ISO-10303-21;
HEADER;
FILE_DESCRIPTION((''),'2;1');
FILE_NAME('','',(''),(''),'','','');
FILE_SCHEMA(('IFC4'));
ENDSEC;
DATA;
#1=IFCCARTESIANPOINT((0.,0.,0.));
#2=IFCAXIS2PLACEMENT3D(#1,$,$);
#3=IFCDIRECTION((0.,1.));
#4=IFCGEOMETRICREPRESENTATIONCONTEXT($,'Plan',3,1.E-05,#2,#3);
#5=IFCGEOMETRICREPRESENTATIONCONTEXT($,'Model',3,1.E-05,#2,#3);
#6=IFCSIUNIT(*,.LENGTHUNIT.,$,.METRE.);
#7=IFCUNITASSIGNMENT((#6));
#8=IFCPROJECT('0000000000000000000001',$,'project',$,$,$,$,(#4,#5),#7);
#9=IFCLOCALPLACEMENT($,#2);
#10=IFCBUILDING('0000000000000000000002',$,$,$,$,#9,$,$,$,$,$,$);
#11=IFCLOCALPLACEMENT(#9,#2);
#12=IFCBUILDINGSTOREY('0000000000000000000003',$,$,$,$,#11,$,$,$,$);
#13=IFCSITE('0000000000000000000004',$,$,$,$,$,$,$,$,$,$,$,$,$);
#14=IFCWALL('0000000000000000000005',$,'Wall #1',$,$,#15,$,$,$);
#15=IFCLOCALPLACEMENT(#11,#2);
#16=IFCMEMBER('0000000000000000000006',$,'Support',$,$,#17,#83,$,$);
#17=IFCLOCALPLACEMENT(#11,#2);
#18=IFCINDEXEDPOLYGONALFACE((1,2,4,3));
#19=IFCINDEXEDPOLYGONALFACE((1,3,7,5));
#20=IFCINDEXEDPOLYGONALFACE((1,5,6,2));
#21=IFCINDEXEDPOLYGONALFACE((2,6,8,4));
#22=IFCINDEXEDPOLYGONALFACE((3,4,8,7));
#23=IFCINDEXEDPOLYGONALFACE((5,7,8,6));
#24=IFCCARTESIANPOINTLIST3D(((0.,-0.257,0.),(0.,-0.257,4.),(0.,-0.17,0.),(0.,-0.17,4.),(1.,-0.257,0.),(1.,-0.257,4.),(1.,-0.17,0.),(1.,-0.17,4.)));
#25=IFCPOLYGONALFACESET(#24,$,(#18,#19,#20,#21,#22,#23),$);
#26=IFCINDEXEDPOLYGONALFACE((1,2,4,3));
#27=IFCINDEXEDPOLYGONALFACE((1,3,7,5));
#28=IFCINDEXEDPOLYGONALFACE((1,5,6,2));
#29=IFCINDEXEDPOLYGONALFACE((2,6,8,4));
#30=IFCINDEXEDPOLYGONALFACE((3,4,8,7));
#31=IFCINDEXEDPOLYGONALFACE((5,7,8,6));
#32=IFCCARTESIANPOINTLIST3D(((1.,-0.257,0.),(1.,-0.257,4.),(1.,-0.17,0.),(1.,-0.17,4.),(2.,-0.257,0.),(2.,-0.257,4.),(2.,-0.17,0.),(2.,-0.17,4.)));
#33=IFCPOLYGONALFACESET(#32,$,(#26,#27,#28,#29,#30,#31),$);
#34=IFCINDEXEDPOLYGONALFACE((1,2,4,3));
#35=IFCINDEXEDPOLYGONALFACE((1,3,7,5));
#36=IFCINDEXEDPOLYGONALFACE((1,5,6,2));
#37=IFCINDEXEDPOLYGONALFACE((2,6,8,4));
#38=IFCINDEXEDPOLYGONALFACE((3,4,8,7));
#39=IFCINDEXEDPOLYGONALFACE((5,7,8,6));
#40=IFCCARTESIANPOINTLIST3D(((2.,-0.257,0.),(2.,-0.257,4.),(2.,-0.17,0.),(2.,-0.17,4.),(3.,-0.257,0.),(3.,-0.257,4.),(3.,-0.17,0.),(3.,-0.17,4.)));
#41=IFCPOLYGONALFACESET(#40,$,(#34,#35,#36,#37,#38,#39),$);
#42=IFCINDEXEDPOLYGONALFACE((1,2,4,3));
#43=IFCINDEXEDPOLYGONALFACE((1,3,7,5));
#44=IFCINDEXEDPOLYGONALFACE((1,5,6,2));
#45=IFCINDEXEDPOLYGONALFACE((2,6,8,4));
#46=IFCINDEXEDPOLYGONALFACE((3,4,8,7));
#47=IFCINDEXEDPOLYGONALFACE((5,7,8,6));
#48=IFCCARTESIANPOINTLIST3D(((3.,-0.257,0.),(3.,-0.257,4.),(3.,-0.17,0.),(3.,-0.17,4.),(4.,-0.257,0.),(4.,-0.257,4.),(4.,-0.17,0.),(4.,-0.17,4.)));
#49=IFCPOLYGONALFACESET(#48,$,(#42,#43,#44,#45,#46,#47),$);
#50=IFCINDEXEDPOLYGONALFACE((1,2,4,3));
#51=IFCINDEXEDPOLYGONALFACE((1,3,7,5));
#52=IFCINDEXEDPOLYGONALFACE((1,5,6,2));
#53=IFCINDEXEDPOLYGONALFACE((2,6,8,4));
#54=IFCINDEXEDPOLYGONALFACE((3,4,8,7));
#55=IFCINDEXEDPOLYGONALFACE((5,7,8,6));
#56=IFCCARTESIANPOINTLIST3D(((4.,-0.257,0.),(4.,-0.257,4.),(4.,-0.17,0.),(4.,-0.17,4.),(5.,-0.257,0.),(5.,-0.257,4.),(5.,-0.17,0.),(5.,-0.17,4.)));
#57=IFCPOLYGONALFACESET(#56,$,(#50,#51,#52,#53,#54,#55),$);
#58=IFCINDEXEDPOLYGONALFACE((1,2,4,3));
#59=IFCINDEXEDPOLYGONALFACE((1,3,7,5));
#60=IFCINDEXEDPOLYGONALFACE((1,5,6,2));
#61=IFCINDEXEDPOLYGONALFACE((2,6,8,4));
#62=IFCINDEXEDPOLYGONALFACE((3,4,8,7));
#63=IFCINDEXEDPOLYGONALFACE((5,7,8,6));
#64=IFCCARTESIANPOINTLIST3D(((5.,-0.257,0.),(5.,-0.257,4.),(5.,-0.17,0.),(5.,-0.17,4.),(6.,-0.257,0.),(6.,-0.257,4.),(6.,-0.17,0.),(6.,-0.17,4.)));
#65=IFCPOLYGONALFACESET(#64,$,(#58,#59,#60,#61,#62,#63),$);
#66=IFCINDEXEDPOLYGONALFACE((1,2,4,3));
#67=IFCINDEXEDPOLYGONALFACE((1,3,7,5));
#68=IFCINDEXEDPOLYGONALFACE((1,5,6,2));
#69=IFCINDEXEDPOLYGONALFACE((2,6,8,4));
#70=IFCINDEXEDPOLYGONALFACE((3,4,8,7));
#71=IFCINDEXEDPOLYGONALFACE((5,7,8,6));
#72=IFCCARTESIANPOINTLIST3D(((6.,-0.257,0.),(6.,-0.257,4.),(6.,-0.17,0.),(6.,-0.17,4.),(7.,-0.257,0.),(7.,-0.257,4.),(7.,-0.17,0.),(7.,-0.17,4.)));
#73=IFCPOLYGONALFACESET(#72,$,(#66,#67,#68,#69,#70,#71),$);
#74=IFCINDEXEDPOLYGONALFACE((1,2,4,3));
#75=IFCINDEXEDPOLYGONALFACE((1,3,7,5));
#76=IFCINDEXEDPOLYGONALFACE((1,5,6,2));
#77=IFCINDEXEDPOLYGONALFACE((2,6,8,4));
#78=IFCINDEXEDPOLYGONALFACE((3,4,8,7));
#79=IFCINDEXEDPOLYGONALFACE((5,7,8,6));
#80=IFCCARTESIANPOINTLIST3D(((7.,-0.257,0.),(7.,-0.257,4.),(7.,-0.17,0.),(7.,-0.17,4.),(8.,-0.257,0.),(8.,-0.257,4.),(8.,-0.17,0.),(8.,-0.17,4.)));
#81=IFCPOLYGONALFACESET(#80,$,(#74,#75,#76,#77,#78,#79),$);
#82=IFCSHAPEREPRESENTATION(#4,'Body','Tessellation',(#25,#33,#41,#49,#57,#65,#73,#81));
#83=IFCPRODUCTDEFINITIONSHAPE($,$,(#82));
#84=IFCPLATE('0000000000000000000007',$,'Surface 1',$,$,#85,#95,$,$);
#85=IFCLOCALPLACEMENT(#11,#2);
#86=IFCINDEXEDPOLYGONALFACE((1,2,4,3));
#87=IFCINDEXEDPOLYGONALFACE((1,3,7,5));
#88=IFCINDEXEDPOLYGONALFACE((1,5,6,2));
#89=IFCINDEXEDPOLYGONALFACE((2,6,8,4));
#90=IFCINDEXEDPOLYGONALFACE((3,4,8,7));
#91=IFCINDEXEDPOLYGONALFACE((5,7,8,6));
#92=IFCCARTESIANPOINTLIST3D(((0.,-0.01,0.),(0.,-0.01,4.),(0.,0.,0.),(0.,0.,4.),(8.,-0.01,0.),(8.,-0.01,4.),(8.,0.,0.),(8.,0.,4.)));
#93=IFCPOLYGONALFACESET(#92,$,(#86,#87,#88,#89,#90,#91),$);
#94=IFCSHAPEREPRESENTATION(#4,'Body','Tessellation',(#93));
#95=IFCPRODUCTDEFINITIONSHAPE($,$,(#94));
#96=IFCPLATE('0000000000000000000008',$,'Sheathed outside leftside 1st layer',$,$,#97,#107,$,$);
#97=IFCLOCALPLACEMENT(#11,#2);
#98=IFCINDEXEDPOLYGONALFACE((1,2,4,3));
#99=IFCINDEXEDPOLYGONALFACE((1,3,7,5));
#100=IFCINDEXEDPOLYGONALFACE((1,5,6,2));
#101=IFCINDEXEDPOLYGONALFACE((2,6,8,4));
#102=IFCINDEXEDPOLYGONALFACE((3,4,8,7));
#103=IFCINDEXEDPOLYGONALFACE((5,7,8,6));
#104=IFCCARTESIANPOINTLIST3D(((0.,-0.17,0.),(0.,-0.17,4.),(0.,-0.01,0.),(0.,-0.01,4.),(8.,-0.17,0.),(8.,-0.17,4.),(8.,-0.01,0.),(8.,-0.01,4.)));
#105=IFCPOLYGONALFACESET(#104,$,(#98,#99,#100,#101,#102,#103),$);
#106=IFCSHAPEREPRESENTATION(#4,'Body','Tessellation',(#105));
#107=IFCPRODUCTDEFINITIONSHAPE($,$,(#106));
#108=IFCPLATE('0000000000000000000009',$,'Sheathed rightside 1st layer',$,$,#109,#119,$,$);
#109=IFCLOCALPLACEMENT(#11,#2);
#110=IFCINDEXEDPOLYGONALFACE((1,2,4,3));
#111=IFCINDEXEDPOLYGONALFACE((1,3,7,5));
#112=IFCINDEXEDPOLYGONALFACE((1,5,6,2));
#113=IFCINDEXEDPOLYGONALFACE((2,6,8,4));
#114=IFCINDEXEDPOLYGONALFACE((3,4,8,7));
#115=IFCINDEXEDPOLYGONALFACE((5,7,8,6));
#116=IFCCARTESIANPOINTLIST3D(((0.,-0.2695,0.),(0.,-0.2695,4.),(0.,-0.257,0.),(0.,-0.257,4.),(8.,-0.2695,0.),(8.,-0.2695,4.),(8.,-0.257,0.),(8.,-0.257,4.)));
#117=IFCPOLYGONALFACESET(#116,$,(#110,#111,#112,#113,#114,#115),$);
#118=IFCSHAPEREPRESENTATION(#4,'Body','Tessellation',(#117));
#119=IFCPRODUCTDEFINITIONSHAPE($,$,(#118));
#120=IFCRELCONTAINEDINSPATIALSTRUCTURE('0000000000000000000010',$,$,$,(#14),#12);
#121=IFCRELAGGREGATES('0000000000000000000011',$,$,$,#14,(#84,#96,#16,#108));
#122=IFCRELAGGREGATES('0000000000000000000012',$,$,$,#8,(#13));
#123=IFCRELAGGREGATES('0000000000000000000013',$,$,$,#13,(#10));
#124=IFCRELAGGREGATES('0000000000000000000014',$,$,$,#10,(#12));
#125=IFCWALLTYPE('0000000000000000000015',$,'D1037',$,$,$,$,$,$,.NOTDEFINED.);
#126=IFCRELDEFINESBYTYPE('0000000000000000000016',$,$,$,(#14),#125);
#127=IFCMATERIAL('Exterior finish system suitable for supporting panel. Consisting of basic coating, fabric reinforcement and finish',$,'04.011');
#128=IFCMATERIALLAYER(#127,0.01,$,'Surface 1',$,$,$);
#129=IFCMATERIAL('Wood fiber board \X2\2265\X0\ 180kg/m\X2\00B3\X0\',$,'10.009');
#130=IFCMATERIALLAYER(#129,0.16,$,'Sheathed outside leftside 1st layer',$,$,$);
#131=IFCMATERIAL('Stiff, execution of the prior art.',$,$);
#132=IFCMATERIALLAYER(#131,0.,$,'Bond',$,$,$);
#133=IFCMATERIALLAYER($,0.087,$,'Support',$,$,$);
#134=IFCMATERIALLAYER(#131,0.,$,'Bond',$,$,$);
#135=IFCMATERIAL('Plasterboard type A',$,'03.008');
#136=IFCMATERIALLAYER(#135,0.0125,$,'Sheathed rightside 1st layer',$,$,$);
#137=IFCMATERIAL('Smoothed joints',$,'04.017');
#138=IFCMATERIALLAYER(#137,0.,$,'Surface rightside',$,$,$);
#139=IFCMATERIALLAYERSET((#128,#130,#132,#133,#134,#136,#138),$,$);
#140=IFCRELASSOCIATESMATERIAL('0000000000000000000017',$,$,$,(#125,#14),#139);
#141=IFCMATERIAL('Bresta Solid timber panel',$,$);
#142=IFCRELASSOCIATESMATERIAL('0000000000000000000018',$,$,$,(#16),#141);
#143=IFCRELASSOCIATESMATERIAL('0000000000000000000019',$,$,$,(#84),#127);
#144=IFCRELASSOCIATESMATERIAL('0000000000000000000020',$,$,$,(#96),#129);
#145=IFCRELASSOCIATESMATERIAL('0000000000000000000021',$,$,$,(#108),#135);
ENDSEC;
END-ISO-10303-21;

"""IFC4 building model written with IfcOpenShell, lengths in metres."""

from ifc_helpers import new_model, si_unit, direction, frame, frame_2d, origin, origin_with_axes, place, context, project, spatial, rectangle, extrude, material, layer, layer_set, type_object, element, aggregate, save


model = new_model("IFC4")

# Units and contexts
plan_context = context("Plan", 3, precision=1e-05, world=origin(), true_north=direction((0.0, 1.0)))
model_context = context("Model", 3, precision=1e-05, world=origin(), true_north=direction((0.0, 1.0)))
ifc_project = project(units=[si_unit("LENGTHUNIT", "METRE")], contexts=[plan_context, model_context])

# Site, building, storey
site = spatial("IfcSite", under=ifc_project)
building_placement = place(None, origin())
building = spatial("IfcBuilding", under=site, at=building_placement)
storey_placement = place(building_placement, origin())
storey = spatial("IfcBuildingStorey", under=building, at=storey_placement)

# Wall, member, plates
ifc_material_1 = material(Name="Exterior finish system suitable for supporting panel. Consisting of basic coating, fabric reinforcement and finish", Category="04.011")
ifc_layer_1 = layer(ifc_material_1, 0.01, Name="Surface 1")
ifc_material_2 = material(Name="Wood fiber board ≥ 180kg/m³", Category="10.009")
ifc_layer_2 = layer(ifc_material_2, 0.16, Name="Sheathed outside leftside 1st layer")
ifc_material_3 = material(Name="Stiff, execution of the prior art.")
ifc_layer_3 = layer(ifc_material_3, 0.0, Name="Bond")
ifc_layer_4 = layer(None, 0.087, Name="Support")
ifc_layer_5 = layer(ifc_material_3, 0.0, Name="Bond")
ifc_material_4 = material(Name="Plasterboard type A", Category="03.008")
ifc_layer_6 = layer(ifc_material_4, 0.0125, Name="Sheathed rightside 1st layer")
ifc_material_5 = material(Name="Smoothed joints", Category="04.017")
ifc_layer_7 = layer(ifc_material_5, 0.0, Name="Surface rightside")
ifc_layer_set = layer_set([ifc_layer_1, ifc_layer_2, ifc_layer_3, ifc_layer_4, ifc_layer_5, ifc_layer_6, ifc_layer_7])
wall_type = type_object("IfcWallType", Name="D1037", PredefinedType="NOTDEFINED", material=ifc_layer_set)
wall_placement = place(None, frame((0.0, 0.0, 0.0), z_axis=(0.0, -1.0, 0.0), x_axis=(1.0, 0.0, 0.0)))
wall = element("IfcWall", 1, at=wall_placement, inside=storey, type_object=wall_type, material=ifc_layer_set, Name="Wall #1")
ifc_material_6 = material(Name="Bresta Solid timber panel")
member_placement = place(wall_placement, origin())
member = element("IfcMember", 2, at=member_placement, material=ifc_material_6, Name="Support", context=plan_context, shape_type="SweptSolid", body=[
    extrude(rectangle(XDim=1.0, YDim=0.087, at=frame_2d((0.5, 0.0435), x_axis=(1.0, 0.0))), frame((0.0, 4.0, 0.17), z_axis=(0.0, -1.0, 0.0), x_axis=(1.0, 0.0, 0.0)), (0.0, 0.0, 1.0), 4.0),
    extrude(rectangle(XDim=1.0, YDim=0.087, at=frame_2d((0.5, 0.0435), x_axis=(1.0, 0.0))), frame((1.0, 4.0, 0.17), z_axis=(0.0, -1.0, 0.0), x_axis=(1.0, 0.0, 0.0)), (0.0, 0.0, 1.0), 4.0),
    extrude(rectangle(XDim=1.0, YDim=0.087, at=frame_2d((0.5, 0.0435), x_axis=(1.0, 0.0))), frame((2.0, 4.0, 0.17), z_axis=(0.0, -1.0, 0.0), x_axis=(1.0, 0.0, 0.0)), (0.0, 0.0, 1.0), 4.0),
    extrude(rectangle(XDim=1.0, YDim=0.087, at=frame_2d((0.5, 0.0435), x_axis=(1.0, 0.0))), frame((3.0, 4.0, 0.17), z_axis=(0.0, -1.0, 0.0), x_axis=(1.0, 0.0, 0.0)), (0.0, 0.0, 1.0), 4.0),
    extrude(rectangle(XDim=1.0, YDim=0.087, at=frame_2d((0.5, 0.0435), x_axis=(1.0, 0.0))), frame((4.0, 4.0, 0.17), z_axis=(0.0, -1.0, 0.0), x_axis=(1.0, 0.0, 0.0)), (0.0, 0.0, 1.0), 4.0),
    extrude(rectangle(XDim=1.0, YDim=0.087, at=frame_2d((0.5, 0.0435), x_axis=(1.0, 0.0))), frame((5.0, 4.0, 0.17), z_axis=(0.0, -1.0, 0.0), x_axis=(1.0, 0.0, 0.0)), (0.0, 0.0, 1.0), 4.0),
    extrude(rectangle(XDim=1.0, YDim=0.087, at=frame_2d((0.5, 0.0435), x_axis=(1.0, 0.0))), frame((6.0, 4.0, 0.17), z_axis=(0.0, -1.0, 0.0), x_axis=(1.0, 0.0, 0.0)), (0.0, 0.0, 1.0), 4.0),
    extrude(rectangle(XDim=1.0, YDim=0.087, at=frame_2d((0.5, 0.0435), x_axis=(1.0, 0.0))), frame((7.0, 4.0, 0.17), z_axis=(0.0, -1.0, 0.0), x_axis=(1.0, 0.0, 0.0)), (0.0, 0.0, 1.0), 4.0),
])
plate_1_placement = place(wall_placement, origin())
plate_1 = element("IfcPlate", 3, at=plate_1_placement, material=ifc_material_1, Name="Surface 1", context=plan_context, shape_type="SweptSolid", body=[
    extrude(rectangle(XDim=8.0, YDim=4.0, at=frame_2d((4.0, 2.0), x_axis=(1.0, 0.0))), origin_with_axes(), (0.0, 0.0, 1.0), 0.01),
])
plate_2_placement = place(wall_placement, origin())
plate_2 = element("IfcPlate", 4, at=plate_2_placement, material=ifc_material_2, Name="Sheathed outside leftside 1st layer", context=plan_context, shape_type="SweptSolid", body=[
    extrude(rectangle(XDim=8.0, YDim=4.0, at=frame_2d((4.0, 2.0), x_axis=(1.0, 0.0))), frame((0.0, 0.0, 0.01), z_axis=(0.0, 0.0, 1.0), x_axis=(1.0, 0.0, 0.0)), (0.0, 0.0, 1.0), 0.16),
])
plate_3_placement = place(wall_placement, origin())
plate_3 = element("IfcPlate", 5, at=plate_3_placement, material=ifc_material_4, Name="Sheathed rightside 1st layer", context=plan_context, shape_type="SweptSolid", body=[
    extrude(rectangle(XDim=8.0, YDim=4.0, at=frame_2d((4.0, 2.0), x_axis=(1.0, 0.0))), frame((0.0, 0.0, 0.257), z_axis=(0.0, 0.0, 1.0), x_axis=(1.0, 0.0, 0.0)), (0.0, 0.0, 1.0), 0.0125),
])
aggregate(wall, [plate_1, plate_2, member, plate_3])

save(model, "model.ifc")
